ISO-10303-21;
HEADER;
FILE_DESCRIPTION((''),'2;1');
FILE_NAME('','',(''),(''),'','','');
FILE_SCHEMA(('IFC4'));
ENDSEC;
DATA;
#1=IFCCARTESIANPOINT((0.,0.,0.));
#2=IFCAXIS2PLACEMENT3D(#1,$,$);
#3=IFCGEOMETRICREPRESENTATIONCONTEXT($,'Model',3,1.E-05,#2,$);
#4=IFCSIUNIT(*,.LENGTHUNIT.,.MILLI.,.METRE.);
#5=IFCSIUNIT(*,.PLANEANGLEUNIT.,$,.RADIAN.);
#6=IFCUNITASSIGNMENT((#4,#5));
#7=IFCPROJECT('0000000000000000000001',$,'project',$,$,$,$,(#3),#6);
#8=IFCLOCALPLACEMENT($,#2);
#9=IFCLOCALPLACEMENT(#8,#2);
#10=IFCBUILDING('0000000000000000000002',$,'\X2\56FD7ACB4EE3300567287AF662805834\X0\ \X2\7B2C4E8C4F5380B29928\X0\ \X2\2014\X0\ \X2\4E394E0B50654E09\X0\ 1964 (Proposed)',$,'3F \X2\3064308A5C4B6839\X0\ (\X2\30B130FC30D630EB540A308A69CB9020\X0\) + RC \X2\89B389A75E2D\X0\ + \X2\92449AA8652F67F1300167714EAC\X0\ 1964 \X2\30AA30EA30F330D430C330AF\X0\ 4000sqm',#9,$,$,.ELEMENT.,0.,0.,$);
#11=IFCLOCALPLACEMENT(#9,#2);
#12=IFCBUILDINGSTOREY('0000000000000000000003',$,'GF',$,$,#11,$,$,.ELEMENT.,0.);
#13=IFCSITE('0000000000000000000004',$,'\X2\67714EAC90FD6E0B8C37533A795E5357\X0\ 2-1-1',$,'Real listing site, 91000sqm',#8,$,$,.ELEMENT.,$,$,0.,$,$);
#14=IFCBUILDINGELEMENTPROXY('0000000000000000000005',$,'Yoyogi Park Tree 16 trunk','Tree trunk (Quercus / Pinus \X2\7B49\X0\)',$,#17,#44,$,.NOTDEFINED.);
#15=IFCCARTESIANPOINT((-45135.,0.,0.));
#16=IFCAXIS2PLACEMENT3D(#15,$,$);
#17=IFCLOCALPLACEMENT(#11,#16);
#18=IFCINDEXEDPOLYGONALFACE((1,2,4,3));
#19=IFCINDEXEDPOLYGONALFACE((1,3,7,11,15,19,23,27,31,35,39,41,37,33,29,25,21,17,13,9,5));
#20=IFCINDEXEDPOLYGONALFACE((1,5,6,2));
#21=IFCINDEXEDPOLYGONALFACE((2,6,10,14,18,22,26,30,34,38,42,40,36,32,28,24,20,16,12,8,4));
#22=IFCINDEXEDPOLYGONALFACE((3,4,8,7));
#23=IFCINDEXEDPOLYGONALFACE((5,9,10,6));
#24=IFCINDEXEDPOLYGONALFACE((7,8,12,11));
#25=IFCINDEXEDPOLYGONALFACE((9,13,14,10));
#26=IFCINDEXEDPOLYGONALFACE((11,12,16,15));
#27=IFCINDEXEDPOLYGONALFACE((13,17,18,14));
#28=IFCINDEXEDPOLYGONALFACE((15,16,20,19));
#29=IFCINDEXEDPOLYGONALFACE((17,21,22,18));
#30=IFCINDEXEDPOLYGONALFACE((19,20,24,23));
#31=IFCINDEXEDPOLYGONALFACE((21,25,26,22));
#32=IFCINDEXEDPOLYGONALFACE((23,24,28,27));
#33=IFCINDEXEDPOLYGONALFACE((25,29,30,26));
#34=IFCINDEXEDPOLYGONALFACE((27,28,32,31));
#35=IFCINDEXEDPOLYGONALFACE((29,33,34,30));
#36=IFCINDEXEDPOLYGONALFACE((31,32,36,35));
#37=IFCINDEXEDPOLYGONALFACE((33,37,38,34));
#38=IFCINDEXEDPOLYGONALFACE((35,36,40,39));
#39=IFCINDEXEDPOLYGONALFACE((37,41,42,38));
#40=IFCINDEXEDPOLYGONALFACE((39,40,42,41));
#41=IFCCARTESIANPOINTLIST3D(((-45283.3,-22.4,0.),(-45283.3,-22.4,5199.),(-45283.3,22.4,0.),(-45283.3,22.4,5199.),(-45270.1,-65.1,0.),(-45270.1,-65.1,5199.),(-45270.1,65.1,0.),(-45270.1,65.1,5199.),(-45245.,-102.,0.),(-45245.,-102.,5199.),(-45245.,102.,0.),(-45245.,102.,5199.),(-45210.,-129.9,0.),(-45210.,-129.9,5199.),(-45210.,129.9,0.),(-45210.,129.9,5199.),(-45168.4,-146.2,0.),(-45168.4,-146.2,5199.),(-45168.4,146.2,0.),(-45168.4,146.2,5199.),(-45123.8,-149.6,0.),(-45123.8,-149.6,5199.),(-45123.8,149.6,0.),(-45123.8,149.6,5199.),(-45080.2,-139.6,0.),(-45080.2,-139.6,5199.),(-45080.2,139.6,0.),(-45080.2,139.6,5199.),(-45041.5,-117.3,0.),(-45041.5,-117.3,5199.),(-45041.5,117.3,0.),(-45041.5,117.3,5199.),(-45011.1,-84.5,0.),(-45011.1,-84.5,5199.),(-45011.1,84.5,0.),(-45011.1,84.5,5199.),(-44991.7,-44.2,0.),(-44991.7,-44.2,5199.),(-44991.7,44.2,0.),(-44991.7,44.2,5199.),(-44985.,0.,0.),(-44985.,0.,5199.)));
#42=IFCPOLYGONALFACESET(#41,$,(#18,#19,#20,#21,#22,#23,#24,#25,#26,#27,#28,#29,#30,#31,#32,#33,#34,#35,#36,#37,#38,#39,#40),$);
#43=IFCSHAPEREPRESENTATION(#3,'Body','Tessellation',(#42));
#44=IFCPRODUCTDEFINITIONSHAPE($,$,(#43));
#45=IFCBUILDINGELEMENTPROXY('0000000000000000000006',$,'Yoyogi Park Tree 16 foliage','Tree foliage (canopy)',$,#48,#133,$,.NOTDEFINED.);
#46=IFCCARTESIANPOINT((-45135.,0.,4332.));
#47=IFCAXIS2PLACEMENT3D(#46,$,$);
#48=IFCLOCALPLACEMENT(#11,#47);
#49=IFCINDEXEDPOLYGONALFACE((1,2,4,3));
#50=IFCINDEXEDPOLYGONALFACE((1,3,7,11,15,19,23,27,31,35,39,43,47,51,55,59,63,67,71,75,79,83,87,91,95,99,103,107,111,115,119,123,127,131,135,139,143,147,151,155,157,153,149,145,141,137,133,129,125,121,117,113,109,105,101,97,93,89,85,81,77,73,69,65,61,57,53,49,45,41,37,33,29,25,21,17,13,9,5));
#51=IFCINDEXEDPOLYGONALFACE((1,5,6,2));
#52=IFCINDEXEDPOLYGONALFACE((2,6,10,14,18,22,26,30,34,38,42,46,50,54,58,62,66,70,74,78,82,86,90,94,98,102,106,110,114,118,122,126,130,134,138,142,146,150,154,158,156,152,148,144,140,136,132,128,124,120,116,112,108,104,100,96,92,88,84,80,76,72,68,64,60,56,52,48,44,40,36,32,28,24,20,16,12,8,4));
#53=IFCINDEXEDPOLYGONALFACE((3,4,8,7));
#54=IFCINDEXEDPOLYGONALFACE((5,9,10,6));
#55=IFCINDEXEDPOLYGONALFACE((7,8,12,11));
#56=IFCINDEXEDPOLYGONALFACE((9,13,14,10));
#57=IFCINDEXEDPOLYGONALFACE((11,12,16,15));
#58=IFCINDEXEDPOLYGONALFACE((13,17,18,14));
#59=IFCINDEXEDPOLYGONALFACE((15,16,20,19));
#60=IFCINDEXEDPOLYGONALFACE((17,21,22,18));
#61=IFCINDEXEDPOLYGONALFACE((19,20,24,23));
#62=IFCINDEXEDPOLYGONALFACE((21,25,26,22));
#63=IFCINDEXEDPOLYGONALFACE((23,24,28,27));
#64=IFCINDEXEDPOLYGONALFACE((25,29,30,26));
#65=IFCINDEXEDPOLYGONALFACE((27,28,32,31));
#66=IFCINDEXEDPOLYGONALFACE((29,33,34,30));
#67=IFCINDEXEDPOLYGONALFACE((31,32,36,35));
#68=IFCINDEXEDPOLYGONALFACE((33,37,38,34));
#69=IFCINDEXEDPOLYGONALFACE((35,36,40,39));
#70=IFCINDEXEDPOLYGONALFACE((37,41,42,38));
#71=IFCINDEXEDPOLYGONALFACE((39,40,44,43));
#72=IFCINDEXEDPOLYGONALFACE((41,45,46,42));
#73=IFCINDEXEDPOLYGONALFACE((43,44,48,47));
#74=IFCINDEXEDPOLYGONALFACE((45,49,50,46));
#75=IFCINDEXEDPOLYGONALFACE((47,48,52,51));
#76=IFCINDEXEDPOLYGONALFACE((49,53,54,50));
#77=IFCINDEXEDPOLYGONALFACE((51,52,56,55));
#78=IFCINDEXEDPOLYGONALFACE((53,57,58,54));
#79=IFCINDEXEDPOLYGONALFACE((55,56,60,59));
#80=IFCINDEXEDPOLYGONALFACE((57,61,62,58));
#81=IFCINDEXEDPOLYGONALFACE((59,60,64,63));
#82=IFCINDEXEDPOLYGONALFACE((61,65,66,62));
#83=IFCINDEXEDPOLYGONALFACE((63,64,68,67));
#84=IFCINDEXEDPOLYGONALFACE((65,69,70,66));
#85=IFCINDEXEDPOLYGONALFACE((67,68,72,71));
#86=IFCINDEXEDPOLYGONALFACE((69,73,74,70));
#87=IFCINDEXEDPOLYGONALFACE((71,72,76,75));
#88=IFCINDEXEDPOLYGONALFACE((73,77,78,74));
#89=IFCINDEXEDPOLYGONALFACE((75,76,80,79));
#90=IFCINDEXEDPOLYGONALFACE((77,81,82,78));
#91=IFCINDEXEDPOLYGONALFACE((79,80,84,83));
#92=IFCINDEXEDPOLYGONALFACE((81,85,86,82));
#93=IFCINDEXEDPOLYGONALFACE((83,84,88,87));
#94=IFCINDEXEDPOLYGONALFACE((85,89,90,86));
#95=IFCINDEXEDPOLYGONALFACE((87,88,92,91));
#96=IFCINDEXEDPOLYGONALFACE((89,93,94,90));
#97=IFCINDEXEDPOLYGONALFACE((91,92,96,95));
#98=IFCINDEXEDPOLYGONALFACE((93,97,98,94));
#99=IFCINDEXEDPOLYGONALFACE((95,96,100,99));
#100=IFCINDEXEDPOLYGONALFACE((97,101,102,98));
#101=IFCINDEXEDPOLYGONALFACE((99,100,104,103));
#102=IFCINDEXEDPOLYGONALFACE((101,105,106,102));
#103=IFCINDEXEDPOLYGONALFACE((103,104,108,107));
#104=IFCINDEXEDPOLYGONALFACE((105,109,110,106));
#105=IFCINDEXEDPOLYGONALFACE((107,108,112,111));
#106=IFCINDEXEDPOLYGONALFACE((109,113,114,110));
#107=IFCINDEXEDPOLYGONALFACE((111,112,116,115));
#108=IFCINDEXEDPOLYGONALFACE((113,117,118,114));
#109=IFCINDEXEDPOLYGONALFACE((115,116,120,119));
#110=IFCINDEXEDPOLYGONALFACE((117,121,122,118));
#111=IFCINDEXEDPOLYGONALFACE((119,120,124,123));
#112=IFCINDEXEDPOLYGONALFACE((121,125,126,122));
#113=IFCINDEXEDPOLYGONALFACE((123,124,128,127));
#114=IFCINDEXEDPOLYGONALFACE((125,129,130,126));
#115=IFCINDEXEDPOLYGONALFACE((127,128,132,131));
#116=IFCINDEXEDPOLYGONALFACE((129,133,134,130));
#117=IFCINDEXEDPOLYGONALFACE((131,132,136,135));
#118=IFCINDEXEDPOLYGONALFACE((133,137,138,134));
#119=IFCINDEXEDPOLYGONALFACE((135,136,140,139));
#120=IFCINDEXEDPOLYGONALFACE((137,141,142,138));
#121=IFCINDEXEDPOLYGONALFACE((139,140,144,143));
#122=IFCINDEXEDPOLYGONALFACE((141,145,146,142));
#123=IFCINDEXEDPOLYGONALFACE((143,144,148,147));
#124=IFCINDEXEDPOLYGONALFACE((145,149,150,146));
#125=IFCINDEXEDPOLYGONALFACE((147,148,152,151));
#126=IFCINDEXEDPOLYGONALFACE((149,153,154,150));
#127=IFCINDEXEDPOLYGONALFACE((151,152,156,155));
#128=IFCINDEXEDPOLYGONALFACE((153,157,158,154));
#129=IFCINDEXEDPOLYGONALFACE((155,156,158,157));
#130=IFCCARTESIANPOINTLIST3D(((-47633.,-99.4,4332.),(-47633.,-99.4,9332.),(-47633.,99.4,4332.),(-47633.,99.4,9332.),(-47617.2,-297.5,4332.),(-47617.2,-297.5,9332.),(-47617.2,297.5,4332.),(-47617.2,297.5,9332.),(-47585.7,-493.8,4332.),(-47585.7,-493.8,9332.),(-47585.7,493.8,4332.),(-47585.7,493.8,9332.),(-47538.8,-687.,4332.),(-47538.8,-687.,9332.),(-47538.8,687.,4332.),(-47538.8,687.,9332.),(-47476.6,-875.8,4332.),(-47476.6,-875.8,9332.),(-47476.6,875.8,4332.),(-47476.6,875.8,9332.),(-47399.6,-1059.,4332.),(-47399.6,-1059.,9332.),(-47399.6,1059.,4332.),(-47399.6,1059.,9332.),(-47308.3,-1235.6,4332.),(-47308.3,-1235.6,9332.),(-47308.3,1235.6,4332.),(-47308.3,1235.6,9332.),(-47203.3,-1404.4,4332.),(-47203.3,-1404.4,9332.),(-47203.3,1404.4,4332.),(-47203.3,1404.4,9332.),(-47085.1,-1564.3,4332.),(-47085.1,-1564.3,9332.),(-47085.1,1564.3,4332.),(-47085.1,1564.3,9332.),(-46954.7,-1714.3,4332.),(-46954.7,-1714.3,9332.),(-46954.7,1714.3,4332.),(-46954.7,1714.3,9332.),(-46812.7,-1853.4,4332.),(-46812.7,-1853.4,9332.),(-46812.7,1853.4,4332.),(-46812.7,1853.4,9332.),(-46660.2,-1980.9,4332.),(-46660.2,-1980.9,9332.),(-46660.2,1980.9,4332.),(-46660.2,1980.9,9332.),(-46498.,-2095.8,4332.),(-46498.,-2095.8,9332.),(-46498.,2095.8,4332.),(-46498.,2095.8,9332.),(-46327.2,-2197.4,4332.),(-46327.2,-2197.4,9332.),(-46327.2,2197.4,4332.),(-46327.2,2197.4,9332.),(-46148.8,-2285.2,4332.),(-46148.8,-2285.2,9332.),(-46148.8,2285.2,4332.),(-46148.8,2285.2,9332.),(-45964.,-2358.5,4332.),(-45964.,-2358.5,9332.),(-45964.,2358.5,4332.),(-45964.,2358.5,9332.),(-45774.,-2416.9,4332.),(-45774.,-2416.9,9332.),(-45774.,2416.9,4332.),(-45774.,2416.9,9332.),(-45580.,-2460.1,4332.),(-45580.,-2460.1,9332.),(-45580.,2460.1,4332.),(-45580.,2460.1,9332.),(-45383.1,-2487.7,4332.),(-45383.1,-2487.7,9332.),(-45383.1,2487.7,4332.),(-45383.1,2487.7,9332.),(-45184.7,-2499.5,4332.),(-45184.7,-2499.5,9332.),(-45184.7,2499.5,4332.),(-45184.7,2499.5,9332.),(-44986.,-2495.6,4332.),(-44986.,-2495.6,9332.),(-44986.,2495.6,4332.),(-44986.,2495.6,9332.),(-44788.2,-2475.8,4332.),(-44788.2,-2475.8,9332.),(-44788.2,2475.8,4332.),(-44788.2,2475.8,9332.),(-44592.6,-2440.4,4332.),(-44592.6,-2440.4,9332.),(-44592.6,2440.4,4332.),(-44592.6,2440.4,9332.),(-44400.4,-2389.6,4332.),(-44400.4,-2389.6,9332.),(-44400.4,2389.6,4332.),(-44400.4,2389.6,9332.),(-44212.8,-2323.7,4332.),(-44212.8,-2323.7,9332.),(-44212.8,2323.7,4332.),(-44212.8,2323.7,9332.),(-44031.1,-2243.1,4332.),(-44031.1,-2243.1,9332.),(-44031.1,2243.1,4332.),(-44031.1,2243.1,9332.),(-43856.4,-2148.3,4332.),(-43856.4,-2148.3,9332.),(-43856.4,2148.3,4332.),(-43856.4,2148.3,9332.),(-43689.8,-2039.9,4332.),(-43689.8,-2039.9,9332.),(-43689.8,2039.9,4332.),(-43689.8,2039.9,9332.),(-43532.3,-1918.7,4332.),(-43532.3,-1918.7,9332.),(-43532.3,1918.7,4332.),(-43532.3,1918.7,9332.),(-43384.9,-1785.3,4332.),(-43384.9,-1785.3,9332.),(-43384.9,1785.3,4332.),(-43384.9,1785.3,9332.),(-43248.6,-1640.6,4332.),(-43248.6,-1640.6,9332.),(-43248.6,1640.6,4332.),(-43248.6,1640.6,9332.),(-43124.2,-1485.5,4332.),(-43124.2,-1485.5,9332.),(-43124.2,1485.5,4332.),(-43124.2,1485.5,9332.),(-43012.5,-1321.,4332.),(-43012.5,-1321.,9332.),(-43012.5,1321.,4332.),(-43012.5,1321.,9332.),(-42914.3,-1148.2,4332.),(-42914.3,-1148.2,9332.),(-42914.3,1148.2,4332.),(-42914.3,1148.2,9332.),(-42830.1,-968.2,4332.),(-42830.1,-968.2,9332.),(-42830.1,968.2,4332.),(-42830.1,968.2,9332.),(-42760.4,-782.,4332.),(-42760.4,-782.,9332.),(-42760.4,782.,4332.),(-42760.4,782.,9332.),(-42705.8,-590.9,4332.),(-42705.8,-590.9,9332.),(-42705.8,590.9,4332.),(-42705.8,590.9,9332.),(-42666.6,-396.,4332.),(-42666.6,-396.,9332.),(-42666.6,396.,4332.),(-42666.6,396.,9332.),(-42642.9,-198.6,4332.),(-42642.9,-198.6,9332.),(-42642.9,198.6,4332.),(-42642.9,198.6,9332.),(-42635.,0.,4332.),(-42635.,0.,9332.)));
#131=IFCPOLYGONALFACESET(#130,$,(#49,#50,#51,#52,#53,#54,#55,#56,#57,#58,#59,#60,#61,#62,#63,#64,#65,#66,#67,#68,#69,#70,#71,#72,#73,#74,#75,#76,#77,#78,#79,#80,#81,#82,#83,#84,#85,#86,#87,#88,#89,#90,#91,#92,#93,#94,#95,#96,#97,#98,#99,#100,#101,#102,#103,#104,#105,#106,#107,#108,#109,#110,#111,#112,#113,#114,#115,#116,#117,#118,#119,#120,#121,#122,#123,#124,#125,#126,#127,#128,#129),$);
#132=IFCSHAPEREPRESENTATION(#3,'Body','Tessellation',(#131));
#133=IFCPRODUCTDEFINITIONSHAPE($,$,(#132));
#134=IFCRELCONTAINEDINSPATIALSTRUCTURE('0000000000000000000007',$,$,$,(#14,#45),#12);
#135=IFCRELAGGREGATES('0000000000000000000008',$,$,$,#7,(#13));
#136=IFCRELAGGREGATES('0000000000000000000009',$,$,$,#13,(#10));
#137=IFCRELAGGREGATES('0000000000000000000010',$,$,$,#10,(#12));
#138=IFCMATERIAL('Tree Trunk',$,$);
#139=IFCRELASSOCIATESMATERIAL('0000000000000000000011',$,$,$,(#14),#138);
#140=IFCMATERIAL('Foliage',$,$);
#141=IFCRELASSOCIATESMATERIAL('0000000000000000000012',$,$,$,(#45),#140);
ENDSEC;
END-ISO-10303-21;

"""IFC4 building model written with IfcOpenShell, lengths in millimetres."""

from ifc_helpers import new_model, si_unit, frame, origin, origin_2d, place, context, project, spatial, circle, extrude, material, element, save


model = new_model("IFC4")

# Units and contexts
model_context = context("Model", 3, precision=1e-05, world=origin())
ifc_project = project(units=[si_unit("LENGTHUNIT", "METRE", prefix="MILLI"), si_unit("PLANEANGLEUNIT", "RADIAN")], contexts=[model_context])

# Site, building, storey
site_placement = place(None, origin())
site = spatial("IfcSite", under=ifc_project, at=site_placement, Name="東京都渋谷区神南 2-1-1", ObjectType="Real listing site, 91000sqm", CompositionType="ELEMENT", RefElevation=0.0)
building_placement = place(site_placement, origin())
building = spatial("IfcBuilding", under=site, at=building_placement, Name="国立代々木競技場 第二体育館 — 丹下健三 1964 (Proposed)", ObjectType="3F つり屋根 (ケーブル吊り構造) + RC 観覧席 + 鉄骨支柱、東京 1964 オリンピック 4000sqm", CompositionType="ELEMENT", ElevationOfRefHeight=0.0, ElevationOfTerrain=0.0)
storey_placement = place(building_placement, origin())
storey = spatial("IfcBuildingStorey", under=building, at=storey_placement, Name="GF", CompositionType="ELEMENT", Elevation=0.0)

# Building element proxies
ifc_material_1 = material(Name="Tree Trunk")
ifc_material_2 = material(Name="Foliage")
proxy_1_placement = place(storey_placement, frame((-45135.0, 0.0, 0.0)))
element("IfcBuildingElementProxy", 1, at=proxy_1_placement, inside=storey, material=ifc_material_1, Name="Yoyogi Park Tree 16 trunk", Description="Tree trunk (Quercus / Pinus 等)", PredefinedType="NOTDEFINED", context=model_context, shape_type="SweptSolid", body=[
    extrude(circle(Radius=150.0, at=origin_2d()), frame((-45135.0, 0.0, 0.0)), (0.0, 0.0, 1.0), 5199.0),
])
proxy_2_placement = place(storey_placement, frame((-45135.0, 0.0, 4332.0)))
element("IfcBuildingElementProxy", 2, at=proxy_2_placement, inside=storey, material=ifc_material_2, Name="Yoyogi Park Tree 16 foliage", Description="Tree foliage (canopy)", PredefinedType="NOTDEFINED", context=model_context, shape_type="SweptSolid", body=[
    extrude(circle(Radius=2500.0, at=origin_2d()), frame((-45135.0, 0.0, 4332.0)), (0.0, 0.0, 1.0), 5000.0),
])

save(model, "model.ifc")
